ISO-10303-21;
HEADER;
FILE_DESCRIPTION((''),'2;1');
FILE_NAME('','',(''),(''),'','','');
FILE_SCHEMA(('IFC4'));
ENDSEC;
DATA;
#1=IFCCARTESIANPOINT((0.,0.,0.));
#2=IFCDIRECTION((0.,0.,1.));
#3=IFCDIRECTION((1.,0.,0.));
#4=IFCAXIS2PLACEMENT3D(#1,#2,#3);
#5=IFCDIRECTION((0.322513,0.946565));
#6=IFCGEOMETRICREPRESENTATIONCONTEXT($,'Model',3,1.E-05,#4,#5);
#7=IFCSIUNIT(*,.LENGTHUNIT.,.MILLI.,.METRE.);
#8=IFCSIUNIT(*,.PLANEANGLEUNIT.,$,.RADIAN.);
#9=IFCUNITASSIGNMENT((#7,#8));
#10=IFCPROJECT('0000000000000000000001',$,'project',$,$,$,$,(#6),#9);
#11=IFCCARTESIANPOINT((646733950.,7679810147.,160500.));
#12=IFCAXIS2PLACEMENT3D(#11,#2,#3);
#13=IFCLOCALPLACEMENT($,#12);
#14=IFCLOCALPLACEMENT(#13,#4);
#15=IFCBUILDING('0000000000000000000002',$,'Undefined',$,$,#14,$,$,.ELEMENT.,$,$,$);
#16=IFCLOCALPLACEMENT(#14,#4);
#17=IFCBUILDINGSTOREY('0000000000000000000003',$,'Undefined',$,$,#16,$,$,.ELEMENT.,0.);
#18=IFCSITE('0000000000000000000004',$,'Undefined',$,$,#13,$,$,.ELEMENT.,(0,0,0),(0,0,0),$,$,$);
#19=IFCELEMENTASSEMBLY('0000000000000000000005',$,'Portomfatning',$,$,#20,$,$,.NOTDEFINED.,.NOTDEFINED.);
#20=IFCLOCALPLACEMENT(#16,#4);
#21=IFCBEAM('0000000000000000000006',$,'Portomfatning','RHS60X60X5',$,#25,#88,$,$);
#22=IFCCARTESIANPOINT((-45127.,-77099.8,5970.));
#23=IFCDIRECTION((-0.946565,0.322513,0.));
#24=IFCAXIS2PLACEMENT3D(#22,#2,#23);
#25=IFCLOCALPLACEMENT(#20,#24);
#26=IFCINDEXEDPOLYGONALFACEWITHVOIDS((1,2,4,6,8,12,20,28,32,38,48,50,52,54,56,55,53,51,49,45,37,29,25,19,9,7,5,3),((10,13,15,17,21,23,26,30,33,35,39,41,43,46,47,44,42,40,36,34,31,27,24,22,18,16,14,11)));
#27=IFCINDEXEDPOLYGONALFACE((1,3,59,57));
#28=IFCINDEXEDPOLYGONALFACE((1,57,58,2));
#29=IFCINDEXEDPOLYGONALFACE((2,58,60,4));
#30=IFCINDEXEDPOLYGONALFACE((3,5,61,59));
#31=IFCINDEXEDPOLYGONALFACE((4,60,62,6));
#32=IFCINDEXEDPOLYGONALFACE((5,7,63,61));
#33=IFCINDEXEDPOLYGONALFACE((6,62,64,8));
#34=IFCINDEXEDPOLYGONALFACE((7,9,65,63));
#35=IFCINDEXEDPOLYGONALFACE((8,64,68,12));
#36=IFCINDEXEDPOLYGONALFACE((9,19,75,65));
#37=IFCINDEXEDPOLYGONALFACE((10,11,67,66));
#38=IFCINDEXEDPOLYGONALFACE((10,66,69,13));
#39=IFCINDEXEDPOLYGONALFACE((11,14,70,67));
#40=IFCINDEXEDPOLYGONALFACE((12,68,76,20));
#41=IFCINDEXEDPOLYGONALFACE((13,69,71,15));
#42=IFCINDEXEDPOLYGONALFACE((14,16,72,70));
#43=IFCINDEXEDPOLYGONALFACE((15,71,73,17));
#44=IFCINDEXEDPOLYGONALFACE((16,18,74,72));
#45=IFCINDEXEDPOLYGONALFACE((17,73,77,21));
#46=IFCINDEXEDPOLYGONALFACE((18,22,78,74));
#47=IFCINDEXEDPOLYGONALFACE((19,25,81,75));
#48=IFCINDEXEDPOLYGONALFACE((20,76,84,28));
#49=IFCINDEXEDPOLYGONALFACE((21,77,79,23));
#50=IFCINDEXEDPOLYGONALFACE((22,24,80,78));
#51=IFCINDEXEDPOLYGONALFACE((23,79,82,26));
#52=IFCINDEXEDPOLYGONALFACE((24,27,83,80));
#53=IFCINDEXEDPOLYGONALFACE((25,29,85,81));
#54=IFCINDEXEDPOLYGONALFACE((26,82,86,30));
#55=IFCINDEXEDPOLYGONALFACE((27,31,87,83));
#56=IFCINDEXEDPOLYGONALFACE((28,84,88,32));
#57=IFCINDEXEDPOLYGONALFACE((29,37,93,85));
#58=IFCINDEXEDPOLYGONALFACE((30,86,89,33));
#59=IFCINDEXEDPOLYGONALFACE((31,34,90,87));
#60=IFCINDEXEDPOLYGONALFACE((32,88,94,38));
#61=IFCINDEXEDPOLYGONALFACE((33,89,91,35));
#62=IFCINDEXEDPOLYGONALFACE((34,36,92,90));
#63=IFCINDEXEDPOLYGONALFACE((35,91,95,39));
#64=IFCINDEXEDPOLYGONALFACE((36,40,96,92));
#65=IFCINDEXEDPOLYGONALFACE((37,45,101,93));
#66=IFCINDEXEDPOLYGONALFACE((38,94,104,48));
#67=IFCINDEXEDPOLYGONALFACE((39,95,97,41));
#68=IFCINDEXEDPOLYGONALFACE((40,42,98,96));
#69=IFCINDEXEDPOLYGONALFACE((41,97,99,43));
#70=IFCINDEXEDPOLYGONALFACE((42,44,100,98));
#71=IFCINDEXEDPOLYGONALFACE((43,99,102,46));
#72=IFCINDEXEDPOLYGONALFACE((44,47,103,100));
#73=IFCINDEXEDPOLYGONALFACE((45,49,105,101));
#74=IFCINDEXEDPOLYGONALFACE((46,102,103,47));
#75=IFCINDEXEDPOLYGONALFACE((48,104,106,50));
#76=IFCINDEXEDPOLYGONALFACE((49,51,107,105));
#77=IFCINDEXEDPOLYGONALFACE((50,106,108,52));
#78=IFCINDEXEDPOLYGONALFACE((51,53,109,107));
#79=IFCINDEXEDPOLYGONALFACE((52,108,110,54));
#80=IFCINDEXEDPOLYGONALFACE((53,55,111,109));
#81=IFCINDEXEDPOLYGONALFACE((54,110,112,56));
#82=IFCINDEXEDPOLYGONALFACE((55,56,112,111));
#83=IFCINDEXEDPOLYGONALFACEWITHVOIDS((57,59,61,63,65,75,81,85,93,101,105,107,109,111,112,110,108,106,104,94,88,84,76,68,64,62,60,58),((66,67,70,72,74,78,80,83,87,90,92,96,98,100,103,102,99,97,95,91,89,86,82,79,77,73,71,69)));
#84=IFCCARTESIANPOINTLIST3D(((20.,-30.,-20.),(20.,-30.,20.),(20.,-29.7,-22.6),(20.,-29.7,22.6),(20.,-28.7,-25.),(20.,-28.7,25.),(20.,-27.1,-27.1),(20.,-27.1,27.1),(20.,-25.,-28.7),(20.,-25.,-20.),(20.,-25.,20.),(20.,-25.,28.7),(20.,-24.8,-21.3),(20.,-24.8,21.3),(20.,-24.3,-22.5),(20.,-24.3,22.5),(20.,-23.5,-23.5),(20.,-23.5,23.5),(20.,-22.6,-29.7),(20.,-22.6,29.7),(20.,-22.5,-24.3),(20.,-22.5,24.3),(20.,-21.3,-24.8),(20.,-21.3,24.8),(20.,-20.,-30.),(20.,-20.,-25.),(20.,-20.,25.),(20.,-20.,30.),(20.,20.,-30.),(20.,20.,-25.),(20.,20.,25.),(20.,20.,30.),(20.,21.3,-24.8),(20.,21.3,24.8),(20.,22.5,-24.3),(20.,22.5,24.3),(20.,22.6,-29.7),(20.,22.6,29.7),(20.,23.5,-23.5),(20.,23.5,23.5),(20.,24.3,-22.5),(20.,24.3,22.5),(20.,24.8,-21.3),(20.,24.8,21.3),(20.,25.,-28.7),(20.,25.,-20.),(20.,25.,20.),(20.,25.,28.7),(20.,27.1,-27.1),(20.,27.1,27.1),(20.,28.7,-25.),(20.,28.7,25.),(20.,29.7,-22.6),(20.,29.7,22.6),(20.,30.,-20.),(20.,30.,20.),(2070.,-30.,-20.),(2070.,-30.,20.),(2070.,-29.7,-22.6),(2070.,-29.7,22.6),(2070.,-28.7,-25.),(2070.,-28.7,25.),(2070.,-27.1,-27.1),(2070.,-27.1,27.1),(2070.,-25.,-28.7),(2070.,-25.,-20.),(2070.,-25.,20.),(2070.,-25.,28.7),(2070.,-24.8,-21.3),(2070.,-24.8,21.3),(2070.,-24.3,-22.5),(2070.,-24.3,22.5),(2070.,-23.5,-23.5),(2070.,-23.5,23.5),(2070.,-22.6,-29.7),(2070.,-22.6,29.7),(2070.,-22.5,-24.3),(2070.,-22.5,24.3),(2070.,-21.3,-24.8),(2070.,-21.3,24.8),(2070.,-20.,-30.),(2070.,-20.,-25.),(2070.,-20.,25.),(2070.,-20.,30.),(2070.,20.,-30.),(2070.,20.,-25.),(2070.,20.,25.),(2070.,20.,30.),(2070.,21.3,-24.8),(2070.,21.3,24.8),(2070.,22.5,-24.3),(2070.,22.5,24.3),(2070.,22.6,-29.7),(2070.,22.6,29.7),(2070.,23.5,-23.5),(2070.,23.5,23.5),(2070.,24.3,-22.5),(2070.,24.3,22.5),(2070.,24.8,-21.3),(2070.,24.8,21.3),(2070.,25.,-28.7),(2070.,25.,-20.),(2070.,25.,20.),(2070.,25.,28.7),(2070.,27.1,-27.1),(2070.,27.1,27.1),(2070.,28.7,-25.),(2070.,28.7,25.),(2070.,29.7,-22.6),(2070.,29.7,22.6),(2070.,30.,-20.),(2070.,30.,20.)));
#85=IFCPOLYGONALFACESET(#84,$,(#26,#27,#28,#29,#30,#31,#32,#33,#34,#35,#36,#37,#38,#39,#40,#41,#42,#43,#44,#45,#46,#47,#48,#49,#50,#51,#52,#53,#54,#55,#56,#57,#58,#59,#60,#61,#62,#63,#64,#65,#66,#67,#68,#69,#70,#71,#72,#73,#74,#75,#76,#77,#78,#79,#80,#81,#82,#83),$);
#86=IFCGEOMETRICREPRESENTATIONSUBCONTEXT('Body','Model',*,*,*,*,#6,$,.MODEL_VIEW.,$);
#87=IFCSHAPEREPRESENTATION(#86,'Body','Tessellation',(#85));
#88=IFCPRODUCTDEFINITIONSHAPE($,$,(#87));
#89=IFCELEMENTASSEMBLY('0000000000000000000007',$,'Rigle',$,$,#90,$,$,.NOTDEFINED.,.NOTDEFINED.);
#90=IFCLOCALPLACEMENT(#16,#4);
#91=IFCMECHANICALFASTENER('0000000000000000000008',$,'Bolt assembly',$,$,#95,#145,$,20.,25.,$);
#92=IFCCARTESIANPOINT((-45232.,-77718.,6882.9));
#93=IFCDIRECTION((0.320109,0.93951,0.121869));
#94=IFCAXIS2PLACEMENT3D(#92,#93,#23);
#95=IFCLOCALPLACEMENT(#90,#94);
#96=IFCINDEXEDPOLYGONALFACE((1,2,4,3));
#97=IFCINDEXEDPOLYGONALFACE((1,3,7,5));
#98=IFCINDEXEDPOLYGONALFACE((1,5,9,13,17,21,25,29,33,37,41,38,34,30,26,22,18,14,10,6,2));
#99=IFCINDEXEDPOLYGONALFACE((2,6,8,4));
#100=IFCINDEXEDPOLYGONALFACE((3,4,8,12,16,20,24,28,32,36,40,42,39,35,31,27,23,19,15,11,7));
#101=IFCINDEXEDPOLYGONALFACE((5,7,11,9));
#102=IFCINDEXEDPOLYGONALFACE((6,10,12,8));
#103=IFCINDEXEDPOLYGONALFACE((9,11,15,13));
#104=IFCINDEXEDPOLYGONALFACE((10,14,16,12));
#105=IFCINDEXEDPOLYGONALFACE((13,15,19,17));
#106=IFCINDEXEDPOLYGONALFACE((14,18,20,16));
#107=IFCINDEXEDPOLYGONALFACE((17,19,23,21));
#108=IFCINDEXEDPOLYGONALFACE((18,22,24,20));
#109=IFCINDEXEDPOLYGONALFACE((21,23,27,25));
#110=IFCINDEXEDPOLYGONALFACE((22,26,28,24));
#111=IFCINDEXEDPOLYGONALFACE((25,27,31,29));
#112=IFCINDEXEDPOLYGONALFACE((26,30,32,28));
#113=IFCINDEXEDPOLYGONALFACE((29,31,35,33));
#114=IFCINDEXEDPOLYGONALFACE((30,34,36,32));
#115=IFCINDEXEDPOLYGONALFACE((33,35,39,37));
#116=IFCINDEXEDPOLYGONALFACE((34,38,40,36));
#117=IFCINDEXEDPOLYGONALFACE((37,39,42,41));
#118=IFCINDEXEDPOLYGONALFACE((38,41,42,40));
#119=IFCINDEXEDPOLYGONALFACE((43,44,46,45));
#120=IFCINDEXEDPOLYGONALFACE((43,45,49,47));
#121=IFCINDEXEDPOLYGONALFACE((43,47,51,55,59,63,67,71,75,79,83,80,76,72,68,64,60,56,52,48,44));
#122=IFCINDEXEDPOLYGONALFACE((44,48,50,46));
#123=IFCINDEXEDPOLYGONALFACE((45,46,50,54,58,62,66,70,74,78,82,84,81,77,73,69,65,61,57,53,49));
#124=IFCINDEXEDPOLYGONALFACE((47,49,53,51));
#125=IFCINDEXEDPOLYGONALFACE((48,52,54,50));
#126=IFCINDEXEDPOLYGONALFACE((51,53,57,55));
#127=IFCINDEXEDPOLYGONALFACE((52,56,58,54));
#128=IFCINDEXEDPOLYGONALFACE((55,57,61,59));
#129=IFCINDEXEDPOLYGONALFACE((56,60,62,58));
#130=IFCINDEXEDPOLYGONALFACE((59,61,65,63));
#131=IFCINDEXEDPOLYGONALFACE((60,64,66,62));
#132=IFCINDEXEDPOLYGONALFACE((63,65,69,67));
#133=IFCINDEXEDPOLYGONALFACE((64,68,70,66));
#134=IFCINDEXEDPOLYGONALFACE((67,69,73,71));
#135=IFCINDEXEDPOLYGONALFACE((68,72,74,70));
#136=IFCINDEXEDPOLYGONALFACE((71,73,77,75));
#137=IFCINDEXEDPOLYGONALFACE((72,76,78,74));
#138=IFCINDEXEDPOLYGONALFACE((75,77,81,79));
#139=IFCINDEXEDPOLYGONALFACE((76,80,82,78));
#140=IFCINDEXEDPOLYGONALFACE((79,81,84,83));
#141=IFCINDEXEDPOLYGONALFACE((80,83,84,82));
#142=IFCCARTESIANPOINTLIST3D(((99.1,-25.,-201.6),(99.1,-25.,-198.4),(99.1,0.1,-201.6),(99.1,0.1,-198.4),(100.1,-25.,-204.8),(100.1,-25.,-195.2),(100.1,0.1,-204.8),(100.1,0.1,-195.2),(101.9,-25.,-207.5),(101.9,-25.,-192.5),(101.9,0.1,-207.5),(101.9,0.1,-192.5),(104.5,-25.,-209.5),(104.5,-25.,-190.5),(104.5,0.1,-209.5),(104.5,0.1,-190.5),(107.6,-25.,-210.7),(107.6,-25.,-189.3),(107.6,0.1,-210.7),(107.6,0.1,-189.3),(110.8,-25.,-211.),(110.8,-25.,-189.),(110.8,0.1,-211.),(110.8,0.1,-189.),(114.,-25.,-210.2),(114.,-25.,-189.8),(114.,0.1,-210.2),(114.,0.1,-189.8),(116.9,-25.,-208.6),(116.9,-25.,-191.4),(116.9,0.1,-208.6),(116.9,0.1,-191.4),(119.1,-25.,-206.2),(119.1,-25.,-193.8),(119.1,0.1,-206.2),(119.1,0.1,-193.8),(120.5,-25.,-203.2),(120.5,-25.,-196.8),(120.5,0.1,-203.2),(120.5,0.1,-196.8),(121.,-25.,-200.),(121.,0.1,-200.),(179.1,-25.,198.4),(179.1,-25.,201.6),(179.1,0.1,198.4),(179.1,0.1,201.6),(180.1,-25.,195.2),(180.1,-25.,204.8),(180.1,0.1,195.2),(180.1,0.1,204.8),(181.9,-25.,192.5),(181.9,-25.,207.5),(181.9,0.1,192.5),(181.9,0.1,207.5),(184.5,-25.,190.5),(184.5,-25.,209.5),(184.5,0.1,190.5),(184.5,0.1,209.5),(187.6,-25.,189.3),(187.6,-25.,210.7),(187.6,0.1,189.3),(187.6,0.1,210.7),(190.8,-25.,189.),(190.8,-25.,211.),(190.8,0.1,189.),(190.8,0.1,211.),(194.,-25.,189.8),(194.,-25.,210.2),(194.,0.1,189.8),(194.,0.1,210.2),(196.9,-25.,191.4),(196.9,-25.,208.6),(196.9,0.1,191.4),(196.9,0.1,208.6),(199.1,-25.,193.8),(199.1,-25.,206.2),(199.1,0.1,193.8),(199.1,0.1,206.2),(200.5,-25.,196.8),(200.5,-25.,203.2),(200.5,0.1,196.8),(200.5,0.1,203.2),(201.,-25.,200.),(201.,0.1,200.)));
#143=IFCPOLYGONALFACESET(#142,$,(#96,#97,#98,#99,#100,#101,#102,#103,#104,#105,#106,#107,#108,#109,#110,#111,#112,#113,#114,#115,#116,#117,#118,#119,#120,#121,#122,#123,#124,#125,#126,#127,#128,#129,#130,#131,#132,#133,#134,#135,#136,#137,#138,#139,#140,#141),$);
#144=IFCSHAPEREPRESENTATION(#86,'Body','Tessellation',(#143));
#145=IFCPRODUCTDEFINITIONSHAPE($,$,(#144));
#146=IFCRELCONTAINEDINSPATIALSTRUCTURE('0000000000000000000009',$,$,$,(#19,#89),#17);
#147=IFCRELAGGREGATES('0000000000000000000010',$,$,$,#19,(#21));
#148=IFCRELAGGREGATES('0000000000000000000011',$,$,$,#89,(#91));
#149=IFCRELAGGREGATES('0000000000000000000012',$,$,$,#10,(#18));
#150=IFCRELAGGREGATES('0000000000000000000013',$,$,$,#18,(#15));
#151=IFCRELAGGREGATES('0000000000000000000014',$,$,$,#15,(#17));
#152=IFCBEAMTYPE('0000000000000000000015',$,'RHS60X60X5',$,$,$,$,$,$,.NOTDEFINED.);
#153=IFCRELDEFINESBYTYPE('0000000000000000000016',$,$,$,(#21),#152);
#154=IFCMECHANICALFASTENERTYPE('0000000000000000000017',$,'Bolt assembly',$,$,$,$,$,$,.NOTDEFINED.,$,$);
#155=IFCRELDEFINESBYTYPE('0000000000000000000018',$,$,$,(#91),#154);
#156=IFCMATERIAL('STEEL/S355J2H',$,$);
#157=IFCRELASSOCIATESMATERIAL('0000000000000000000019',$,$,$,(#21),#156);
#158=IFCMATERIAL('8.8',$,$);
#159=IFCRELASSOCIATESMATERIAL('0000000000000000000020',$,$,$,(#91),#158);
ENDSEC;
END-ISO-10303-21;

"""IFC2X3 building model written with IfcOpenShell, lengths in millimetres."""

from ifc_helpers import new_model, si_unit, direction, frame, origin_with_axes, origin_2d_with_axis, place, context, subcontext, project, spatial, hollow_rectangle, circle, extrude, clip, halfspace, source, transform, mapped, material, type_object, element, aggregate, save


model = new_model("IFC2X3")

# Units and contexts
model_context = context("Model", 3, precision=1e-05, world=origin_with_axes(), true_north=direction((0.322513, 0.946565)))
body_context = subcontext(model_context, "Body", "Model", "MODEL_VIEW")
ifc_project = project(units=[si_unit("LENGTHUNIT", "METRE", prefix="MILLI"), si_unit("PLANEANGLEUNIT", "RADIAN")], contexts=[model_context])

# Site, building, storey
site_placement = place(None, frame((646733950.0, 7679810147.0, 160500.0), z_axis=(0.0, 0.0, 1.0), x_axis=(1.0, 0.0, 0.0)))
site = spatial("IfcSite", under=ifc_project, at=site_placement, Name="Undefined", CompositionType="ELEMENT", RefLatitude=(0, 0, 0), RefLongitude=(0, 0, 0))
building_placement = place(site_placement, origin_with_axes())
building = spatial("IfcBuilding", under=site, at=building_placement, Name="Undefined", CompositionType="ELEMENT")
storey_placement = place(building_placement, origin_with_axes())
storey = spatial("IfcBuildingStorey", under=building, at=storey_placement, Name="Undefined", CompositionType="ELEMENT", Elevation=0.0)

# Shared definitions
ifc_material_1 = material(Name="STEEL/S355J2H")

# Element assembly, beam
assembly_1_placement = place(storey_placement, origin_with_axes())
assembly_1 = element("IfcElementAssembly", 1, at=assembly_1_placement, inside=storey, Name="Portomfatning", AssemblyPlace="NOTDEFINED", PredefinedType="NOTDEFINED")
beam_type_1 = type_object("IfcBeamType", Name="RHS60X60X5", PredefinedType="NOTDEFINED")
beam_1_placement = place(assembly_1_placement, frame((-45127.0, -77099.8, 5970.0), z_axis=(0.0, 0.0, 1.0), x_axis=(-0.946565, 0.322513, 0.0)))
beam_1 = element("IfcBeam", 2, at=beam_1_placement, type_object=beam_type_1, material=ifc_material_1, Name="Portomfatning", Description="RHS60X60X5", context=body_context, shape_type="Clipping", body=[
    clip(clip(extrude(hollow_rectangle(XDim=60.0, YDim=60.0, WallThickness=5.0, InnerFilletRadius=5.0, OuterFilletRadius=10.0, at=origin_2d_with_axis()), frame((2107.0, 0.0, 0.0), z_axis=(-1.0, 0.0, 0.0), x_axis=(0.0, -1.0, 0.0)), (0.0, 0.0, 1.0), 2124.0), halfspace(frame((2070.0, 0.0, -30.0), z_axis=(-1.0, 0.0, 0.0), x_axis=(0.0, 1.0, 0.0)), True)), halfspace(frame((20.0, 0.0, -30.0), z_axis=(1.0, 0.0, 0.0), x_axis=(0.0, -1.0, 0.0)), True)),
])

# Element assembly
assembly_2_placement = place(storey_placement, origin_with_axes())
assembly_2 = element("IfcElementAssembly", 3, at=assembly_2_placement, inside=storey, Name="Rigle", AssemblyPlace="NOTDEFINED", PredefinedType="NOTDEFINED")

# Shared definitions
ifc_material_2 = material(Name="8.8")
mechanical_fastener_type = type_object("IfcMechanicalFastenerType", Name="Bolt assembly")

# Mechanical fastener
aggregate(assembly_1, [beam_1])
shared_shape_1 = source(origin_with_axes(), body_context, "Body", "SweptSolid", [
    extrude(circle(Radius=11.0, at=origin_2d_with_axis()), frame((0.0, -25.0, 0.0), z_axis=(0.0, 1.0, 0.0), x_axis=(1.0, 0.0, 0.0)), (0.0, 0.0, 1.0), 25.1),
])
mechanical_fastener_1_placement = place(assembly_2_placement, frame((-45232.0, -77718.0, 6882.9), z_axis=(0.320109, 0.93951, 0.121869), x_axis=(-0.946565, 0.322513, 0.0)))
mechanical_fastener_1 = element("IfcMechanicalFastener", 4, at=mechanical_fastener_1_placement, type_object=mechanical_fastener_type, material=ifc_material_2, Name="Bolt assembly", NominalDiameter=20.0, NominalLength=25.0, context=body_context, shape_type="MappedRepresentation", body=[
    mapped(shared_shape_1, transform((110.0, 0.0, -200.0))),
    mapped(shared_shape_1, transform((190.0, 0.0, 200.0))),
])
aggregate(assembly_2, [mechanical_fastener_1])

save(model, "model.ifc")
